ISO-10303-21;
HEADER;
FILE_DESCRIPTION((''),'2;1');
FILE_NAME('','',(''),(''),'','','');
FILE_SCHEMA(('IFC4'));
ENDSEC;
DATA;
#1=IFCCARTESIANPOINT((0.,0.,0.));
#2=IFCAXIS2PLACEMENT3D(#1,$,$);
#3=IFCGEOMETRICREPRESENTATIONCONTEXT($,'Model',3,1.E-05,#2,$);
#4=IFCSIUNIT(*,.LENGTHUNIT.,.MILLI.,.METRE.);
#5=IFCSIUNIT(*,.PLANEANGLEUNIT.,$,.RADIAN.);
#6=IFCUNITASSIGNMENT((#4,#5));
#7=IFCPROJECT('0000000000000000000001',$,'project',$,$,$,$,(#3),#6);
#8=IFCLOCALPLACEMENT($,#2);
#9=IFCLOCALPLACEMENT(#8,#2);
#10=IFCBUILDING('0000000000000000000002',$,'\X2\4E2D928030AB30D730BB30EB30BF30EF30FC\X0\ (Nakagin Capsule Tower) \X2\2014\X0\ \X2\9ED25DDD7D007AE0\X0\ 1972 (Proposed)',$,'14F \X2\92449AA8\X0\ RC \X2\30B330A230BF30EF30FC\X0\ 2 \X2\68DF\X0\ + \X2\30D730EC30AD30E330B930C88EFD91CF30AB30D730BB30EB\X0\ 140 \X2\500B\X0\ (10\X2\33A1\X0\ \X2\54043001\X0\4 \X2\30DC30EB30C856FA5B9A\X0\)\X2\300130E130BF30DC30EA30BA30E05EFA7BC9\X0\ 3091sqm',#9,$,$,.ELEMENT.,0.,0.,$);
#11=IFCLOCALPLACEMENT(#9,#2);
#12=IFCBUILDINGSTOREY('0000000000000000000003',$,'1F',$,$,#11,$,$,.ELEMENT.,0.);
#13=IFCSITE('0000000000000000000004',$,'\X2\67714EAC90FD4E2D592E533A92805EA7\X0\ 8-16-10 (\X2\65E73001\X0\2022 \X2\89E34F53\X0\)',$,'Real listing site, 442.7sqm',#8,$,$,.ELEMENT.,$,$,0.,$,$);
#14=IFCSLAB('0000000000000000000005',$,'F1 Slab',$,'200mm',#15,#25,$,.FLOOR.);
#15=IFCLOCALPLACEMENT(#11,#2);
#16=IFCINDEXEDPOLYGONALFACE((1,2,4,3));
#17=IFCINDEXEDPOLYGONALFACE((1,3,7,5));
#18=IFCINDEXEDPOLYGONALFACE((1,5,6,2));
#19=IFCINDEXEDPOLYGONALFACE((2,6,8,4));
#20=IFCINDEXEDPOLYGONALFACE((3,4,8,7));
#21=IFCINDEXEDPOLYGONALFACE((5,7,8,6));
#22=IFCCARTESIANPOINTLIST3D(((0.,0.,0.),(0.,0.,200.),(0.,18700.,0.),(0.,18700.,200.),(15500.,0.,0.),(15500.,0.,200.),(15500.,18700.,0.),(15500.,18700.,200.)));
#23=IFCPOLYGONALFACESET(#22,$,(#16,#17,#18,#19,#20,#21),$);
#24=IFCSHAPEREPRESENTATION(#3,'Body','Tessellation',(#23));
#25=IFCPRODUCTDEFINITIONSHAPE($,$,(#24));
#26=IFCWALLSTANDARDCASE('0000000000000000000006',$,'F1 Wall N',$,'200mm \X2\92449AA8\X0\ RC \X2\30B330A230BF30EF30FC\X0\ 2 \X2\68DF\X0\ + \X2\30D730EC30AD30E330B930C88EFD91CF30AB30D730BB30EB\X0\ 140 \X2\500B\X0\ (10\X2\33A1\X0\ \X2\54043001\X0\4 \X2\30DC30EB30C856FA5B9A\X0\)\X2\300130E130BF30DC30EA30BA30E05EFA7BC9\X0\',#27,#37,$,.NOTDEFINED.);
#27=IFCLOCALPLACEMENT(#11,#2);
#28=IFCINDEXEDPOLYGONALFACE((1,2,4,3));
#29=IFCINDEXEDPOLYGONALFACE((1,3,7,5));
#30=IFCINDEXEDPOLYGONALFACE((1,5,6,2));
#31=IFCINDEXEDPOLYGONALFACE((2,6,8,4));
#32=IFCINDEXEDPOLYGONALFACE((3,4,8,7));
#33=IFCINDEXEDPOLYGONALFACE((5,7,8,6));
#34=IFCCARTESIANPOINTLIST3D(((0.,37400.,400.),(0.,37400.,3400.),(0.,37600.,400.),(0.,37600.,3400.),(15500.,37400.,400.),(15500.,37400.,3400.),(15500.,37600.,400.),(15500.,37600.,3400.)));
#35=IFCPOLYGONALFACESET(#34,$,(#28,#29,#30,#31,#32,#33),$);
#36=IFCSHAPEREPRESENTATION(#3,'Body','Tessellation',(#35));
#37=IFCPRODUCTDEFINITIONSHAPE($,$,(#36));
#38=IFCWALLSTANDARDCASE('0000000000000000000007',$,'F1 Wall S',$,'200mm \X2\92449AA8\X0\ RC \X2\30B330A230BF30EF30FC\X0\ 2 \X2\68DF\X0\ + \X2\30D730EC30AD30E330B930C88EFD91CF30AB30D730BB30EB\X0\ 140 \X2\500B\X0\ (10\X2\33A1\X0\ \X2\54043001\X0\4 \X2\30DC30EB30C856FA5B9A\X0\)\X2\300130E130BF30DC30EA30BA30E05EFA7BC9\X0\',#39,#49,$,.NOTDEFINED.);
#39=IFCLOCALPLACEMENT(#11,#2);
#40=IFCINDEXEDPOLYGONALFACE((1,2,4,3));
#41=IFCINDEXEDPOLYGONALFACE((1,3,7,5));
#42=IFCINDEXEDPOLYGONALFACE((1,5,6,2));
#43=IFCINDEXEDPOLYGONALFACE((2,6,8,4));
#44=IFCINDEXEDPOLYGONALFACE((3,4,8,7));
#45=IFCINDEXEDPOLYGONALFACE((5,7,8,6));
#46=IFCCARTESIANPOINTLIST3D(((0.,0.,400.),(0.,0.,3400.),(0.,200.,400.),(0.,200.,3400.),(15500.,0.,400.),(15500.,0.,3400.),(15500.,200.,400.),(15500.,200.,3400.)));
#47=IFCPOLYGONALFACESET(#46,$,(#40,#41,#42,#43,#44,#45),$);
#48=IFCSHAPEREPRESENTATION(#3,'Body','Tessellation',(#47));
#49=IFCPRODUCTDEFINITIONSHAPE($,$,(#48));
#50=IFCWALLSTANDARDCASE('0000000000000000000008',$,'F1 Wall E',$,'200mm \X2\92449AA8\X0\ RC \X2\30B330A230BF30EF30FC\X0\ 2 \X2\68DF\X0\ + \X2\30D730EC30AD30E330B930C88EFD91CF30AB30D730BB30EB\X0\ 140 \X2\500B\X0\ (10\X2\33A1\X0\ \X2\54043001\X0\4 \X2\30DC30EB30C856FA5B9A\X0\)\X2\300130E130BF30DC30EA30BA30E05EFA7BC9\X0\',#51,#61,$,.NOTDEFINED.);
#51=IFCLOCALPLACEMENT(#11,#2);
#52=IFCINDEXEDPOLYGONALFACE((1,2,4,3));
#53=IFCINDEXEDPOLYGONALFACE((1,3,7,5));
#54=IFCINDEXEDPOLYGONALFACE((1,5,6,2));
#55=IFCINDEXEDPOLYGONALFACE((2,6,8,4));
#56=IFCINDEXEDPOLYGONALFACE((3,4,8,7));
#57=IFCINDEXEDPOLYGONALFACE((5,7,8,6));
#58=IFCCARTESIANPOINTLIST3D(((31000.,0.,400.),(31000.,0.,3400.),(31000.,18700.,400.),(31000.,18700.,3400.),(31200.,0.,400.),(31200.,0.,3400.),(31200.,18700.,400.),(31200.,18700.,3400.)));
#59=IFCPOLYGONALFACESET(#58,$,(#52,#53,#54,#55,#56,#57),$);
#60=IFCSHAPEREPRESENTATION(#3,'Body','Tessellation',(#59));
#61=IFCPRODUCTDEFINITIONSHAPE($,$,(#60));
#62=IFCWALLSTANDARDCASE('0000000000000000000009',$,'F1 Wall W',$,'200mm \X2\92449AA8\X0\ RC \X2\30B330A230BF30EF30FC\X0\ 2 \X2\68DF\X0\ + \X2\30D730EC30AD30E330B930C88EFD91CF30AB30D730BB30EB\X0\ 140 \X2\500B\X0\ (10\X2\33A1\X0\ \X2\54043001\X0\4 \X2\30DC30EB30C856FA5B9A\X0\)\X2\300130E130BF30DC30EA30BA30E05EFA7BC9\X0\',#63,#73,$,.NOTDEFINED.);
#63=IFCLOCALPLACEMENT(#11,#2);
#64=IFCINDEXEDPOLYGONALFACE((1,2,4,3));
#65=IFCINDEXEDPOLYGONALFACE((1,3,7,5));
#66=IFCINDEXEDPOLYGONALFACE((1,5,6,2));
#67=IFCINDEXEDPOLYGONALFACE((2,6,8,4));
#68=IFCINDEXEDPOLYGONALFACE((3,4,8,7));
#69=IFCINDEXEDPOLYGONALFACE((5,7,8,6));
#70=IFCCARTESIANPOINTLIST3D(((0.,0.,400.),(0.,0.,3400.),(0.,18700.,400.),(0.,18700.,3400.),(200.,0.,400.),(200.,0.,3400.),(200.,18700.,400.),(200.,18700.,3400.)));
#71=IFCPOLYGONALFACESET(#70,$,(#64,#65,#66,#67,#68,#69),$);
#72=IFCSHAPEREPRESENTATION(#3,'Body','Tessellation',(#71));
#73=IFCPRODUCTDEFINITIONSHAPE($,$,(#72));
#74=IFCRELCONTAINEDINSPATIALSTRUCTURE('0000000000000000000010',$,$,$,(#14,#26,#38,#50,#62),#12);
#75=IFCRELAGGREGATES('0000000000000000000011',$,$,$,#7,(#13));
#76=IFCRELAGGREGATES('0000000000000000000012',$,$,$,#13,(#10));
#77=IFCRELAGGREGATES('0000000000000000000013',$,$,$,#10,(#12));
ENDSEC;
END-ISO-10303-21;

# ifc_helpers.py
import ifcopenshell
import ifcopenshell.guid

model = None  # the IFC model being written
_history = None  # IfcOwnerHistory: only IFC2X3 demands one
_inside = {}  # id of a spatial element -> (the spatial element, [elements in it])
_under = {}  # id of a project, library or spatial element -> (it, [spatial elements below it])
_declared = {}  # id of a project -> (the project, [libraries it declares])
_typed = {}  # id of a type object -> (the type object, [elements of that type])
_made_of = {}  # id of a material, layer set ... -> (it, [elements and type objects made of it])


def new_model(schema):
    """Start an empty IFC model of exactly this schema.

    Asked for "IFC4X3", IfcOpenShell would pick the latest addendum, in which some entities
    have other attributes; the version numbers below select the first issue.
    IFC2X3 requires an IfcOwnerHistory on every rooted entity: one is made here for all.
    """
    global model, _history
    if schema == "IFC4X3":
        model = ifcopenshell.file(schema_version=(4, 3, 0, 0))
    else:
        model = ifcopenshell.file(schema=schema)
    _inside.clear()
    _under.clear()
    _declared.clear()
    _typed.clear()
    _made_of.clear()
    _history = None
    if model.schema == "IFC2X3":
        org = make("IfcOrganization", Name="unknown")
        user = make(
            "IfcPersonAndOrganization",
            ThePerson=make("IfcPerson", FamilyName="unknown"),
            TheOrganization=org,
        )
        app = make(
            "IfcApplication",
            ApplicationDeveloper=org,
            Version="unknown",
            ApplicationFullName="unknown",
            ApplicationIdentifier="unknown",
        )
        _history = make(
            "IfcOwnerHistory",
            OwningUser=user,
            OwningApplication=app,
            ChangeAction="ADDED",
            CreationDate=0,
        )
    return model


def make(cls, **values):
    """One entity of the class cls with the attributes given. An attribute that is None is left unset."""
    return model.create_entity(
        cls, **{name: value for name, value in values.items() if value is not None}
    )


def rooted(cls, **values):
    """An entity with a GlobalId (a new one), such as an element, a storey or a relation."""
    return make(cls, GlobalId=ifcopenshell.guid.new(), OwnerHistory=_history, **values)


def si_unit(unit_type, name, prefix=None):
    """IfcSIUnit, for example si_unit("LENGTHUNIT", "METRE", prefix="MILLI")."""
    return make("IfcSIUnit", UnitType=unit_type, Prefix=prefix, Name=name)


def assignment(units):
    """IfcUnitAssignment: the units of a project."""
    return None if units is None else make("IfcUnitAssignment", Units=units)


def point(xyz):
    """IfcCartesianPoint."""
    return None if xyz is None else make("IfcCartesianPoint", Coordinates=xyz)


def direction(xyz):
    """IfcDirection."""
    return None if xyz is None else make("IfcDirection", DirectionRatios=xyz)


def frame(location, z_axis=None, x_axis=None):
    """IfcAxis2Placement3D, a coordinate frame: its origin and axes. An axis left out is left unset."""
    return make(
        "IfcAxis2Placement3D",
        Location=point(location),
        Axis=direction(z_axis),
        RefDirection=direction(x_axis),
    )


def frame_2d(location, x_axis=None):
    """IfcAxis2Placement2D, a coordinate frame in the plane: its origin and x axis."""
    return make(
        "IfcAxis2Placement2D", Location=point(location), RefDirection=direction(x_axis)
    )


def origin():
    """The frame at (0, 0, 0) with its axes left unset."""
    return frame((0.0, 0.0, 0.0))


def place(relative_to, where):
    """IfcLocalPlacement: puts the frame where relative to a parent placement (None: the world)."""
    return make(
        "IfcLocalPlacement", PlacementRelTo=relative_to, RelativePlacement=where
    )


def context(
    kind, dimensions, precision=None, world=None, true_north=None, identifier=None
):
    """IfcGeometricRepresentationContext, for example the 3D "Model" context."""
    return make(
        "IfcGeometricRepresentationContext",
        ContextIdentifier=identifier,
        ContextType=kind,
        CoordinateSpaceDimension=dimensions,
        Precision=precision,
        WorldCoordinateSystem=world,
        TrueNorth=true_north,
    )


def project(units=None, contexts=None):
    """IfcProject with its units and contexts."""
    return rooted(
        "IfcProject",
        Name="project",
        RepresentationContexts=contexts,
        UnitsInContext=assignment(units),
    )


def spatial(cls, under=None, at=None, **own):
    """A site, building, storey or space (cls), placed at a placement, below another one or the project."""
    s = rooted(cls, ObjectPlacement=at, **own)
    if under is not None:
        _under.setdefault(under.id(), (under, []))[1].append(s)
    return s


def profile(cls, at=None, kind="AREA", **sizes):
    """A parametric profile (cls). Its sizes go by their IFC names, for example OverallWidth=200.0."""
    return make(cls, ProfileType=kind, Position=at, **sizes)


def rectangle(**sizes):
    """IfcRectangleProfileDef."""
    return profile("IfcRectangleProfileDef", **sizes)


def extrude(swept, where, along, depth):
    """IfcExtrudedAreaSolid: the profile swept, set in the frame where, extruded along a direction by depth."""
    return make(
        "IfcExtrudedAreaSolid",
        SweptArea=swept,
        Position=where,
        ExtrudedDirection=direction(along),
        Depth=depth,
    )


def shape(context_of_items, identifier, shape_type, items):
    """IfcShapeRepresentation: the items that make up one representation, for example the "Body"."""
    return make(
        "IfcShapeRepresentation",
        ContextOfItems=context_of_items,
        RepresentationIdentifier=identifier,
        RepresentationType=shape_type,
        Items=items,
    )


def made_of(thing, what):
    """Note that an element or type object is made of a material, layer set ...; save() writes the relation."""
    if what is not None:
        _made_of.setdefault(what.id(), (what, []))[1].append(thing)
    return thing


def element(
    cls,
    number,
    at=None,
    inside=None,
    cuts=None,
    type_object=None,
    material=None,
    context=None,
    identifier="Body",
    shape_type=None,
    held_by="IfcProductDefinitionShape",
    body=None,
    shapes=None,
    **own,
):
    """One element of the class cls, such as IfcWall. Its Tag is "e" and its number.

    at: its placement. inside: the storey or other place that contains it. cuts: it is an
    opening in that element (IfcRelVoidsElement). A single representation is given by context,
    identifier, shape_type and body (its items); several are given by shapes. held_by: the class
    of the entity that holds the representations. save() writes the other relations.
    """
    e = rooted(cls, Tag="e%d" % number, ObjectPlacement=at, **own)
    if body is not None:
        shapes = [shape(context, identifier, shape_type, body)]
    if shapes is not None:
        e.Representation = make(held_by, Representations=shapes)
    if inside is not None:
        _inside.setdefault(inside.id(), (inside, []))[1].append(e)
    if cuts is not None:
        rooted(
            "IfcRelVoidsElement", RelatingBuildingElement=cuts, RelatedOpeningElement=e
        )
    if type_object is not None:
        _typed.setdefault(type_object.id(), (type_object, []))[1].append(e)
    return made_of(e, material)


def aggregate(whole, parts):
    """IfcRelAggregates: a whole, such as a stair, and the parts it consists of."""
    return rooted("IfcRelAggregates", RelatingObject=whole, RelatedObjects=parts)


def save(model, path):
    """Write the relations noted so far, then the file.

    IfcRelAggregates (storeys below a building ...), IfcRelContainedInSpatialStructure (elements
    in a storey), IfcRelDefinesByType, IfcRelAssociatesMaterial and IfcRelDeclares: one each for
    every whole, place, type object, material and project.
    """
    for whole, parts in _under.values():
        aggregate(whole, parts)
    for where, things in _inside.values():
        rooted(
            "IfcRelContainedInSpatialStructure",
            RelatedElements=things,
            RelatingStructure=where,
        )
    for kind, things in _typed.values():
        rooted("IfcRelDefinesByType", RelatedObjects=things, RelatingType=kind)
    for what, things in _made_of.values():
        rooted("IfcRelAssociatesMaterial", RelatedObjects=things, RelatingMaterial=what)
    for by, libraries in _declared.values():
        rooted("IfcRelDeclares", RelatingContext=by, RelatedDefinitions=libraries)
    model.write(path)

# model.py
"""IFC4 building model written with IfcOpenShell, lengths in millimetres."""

from ifc_helpers import new_model, si_unit, frame, frame_2d, origin, place, context, project, spatial, rectangle, extrude, element, save


model = new_model("IFC4")

# Units and contexts
model_context = context("Model", 3, precision=1e-05, world=origin())
ifc_project = project(units=[si_unit("LENGTHUNIT", "METRE", prefix="MILLI"), si_unit("PLANEANGLEUNIT", "RADIAN")], contexts=[model_context])

# Site, building, storey
site_placement = place(None, origin())
site = spatial("IfcSite", under=ifc_project, at=site_placement, Name="東京都中央区銀座 8-16-10 (旧、2022 解体)", ObjectType="Real listing site, 442.7sqm", CompositionType="ELEMENT", RefElevation=0.0)
building_placement = place(site_placement, origin())
building = spatial("IfcBuilding", under=site, at=building_placement, Name="中銀カプセルタワー (Nakagin Capsule Tower) — 黒川紀章 1972 (Proposed)", ObjectType="14F 鉄骨 RC コアタワー 2 棟 + プレキャスト軽量カプセル 140 個 (10㎡ 各、4 ボルト固定)、メタボリズム建築 3091sqm", CompositionType="ELEMENT", ElevationOfRefHeight=0.0, ElevationOfTerrain=0.0)
storey_placement = place(building_placement, origin())
storey = spatial("IfcBuildingStorey", under=building, at=storey_placement, Name="1F", CompositionType="ELEMENT", Elevation=0.0)

# Slab
slab_placement = place(storey_placement, origin())
element("IfcSlab", 1, at=slab_placement, inside=storey, Name="F1 Slab", ObjectType="200mm", PredefinedType="FLOOR", context=model_context, shape_type="SweptSolid", body=[
    extrude(rectangle(XDim=15500.0, YDim=18700.0, at=frame_2d((7750.0, 9350.0))), origin(), (0.0, 0.0, 1.0), 200.0),
])

# Walls
wall_1_placement = place(storey_placement, frame((0.0, 18700.0, 200.0)))
element("IfcWallStandardCase", 2, at=wall_1_placement, inside=storey, Name="F1 Wall N", ObjectType="200mm 鉄骨 RC コアタワー 2 棟 + プレキャスト軽量カプセル 140 個 (10㎡ 各、4 ボルト固定)、メタボリズム建築", PredefinedType="NOTDEFINED", context=model_context, shape_type="SweptSolid", body=[
    extrude(rectangle(XDim=15500.0, YDim=200.0, at=frame_2d((7750.0, 100.0))), frame((0.0, 18700.0, 200.0)), (0.0, 0.0, 1.0), 3000.0),
])
wall_2_placement = place(storey_placement, frame((0.0, 0.0, 200.0)))
element("IfcWallStandardCase", 3, at=wall_2_placement, inside=storey, Name="F1 Wall S", ObjectType="200mm 鉄骨 RC コアタワー 2 棟 + プレキャスト軽量カプセル 140 個 (10㎡ 各、4 ボルト固定)、メタボリズム建築", PredefinedType="NOTDEFINED", context=model_context, shape_type="SweptSolid", body=[
    extrude(rectangle(XDim=15500.0, YDim=200.0, at=frame_2d((7750.0, 100.0))), frame((0.0, 0.0, 200.0)), (0.0, 0.0, 1.0), 3000.0),
])
wall_3_placement = place(storey_placement, frame((15500.0, 0.0, 200.0)))
element("IfcWallStandardCase", 4, at=wall_3_placement, inside=storey, Name="F1 Wall E", ObjectType="200mm 鉄骨 RC コアタワー 2 棟 + プレキャスト軽量カプセル 140 個 (10㎡ 各、4 ボルト固定)、メタボリズム建築", PredefinedType="NOTDEFINED", context=model_context, shape_type="SweptSolid", body=[
    extrude(rectangle(XDim=200.0, YDim=18700.0, at=frame_2d((100.0, 9350.0))), frame((15500.0, 0.0, 200.0)), (0.0, 0.0, 1.0), 3000.0),
])
wall_4_placement = place(storey_placement, frame((0.0, 0.0, 200.0)))
element("IfcWallStandardCase", 5, at=wall_4_placement, inside=storey, Name="F1 Wall W", ObjectType="200mm 鉄骨 RC コアタワー 2 棟 + プレキャスト軽量カプセル 140 個 (10㎡ 各、4 ボルト固定)、メタボリズム建築", PredefinedType="NOTDEFINED", context=model_context, shape_type="SweptSolid", body=[
    extrude(rectangle(XDim=200.0, YDim=18700.0, at=frame_2d((100.0, 9350.0))), frame((0.0, 0.0, 200.0)), (0.0, 0.0, 1.0), 3000.0),
])

save(model, "model.ifc")
